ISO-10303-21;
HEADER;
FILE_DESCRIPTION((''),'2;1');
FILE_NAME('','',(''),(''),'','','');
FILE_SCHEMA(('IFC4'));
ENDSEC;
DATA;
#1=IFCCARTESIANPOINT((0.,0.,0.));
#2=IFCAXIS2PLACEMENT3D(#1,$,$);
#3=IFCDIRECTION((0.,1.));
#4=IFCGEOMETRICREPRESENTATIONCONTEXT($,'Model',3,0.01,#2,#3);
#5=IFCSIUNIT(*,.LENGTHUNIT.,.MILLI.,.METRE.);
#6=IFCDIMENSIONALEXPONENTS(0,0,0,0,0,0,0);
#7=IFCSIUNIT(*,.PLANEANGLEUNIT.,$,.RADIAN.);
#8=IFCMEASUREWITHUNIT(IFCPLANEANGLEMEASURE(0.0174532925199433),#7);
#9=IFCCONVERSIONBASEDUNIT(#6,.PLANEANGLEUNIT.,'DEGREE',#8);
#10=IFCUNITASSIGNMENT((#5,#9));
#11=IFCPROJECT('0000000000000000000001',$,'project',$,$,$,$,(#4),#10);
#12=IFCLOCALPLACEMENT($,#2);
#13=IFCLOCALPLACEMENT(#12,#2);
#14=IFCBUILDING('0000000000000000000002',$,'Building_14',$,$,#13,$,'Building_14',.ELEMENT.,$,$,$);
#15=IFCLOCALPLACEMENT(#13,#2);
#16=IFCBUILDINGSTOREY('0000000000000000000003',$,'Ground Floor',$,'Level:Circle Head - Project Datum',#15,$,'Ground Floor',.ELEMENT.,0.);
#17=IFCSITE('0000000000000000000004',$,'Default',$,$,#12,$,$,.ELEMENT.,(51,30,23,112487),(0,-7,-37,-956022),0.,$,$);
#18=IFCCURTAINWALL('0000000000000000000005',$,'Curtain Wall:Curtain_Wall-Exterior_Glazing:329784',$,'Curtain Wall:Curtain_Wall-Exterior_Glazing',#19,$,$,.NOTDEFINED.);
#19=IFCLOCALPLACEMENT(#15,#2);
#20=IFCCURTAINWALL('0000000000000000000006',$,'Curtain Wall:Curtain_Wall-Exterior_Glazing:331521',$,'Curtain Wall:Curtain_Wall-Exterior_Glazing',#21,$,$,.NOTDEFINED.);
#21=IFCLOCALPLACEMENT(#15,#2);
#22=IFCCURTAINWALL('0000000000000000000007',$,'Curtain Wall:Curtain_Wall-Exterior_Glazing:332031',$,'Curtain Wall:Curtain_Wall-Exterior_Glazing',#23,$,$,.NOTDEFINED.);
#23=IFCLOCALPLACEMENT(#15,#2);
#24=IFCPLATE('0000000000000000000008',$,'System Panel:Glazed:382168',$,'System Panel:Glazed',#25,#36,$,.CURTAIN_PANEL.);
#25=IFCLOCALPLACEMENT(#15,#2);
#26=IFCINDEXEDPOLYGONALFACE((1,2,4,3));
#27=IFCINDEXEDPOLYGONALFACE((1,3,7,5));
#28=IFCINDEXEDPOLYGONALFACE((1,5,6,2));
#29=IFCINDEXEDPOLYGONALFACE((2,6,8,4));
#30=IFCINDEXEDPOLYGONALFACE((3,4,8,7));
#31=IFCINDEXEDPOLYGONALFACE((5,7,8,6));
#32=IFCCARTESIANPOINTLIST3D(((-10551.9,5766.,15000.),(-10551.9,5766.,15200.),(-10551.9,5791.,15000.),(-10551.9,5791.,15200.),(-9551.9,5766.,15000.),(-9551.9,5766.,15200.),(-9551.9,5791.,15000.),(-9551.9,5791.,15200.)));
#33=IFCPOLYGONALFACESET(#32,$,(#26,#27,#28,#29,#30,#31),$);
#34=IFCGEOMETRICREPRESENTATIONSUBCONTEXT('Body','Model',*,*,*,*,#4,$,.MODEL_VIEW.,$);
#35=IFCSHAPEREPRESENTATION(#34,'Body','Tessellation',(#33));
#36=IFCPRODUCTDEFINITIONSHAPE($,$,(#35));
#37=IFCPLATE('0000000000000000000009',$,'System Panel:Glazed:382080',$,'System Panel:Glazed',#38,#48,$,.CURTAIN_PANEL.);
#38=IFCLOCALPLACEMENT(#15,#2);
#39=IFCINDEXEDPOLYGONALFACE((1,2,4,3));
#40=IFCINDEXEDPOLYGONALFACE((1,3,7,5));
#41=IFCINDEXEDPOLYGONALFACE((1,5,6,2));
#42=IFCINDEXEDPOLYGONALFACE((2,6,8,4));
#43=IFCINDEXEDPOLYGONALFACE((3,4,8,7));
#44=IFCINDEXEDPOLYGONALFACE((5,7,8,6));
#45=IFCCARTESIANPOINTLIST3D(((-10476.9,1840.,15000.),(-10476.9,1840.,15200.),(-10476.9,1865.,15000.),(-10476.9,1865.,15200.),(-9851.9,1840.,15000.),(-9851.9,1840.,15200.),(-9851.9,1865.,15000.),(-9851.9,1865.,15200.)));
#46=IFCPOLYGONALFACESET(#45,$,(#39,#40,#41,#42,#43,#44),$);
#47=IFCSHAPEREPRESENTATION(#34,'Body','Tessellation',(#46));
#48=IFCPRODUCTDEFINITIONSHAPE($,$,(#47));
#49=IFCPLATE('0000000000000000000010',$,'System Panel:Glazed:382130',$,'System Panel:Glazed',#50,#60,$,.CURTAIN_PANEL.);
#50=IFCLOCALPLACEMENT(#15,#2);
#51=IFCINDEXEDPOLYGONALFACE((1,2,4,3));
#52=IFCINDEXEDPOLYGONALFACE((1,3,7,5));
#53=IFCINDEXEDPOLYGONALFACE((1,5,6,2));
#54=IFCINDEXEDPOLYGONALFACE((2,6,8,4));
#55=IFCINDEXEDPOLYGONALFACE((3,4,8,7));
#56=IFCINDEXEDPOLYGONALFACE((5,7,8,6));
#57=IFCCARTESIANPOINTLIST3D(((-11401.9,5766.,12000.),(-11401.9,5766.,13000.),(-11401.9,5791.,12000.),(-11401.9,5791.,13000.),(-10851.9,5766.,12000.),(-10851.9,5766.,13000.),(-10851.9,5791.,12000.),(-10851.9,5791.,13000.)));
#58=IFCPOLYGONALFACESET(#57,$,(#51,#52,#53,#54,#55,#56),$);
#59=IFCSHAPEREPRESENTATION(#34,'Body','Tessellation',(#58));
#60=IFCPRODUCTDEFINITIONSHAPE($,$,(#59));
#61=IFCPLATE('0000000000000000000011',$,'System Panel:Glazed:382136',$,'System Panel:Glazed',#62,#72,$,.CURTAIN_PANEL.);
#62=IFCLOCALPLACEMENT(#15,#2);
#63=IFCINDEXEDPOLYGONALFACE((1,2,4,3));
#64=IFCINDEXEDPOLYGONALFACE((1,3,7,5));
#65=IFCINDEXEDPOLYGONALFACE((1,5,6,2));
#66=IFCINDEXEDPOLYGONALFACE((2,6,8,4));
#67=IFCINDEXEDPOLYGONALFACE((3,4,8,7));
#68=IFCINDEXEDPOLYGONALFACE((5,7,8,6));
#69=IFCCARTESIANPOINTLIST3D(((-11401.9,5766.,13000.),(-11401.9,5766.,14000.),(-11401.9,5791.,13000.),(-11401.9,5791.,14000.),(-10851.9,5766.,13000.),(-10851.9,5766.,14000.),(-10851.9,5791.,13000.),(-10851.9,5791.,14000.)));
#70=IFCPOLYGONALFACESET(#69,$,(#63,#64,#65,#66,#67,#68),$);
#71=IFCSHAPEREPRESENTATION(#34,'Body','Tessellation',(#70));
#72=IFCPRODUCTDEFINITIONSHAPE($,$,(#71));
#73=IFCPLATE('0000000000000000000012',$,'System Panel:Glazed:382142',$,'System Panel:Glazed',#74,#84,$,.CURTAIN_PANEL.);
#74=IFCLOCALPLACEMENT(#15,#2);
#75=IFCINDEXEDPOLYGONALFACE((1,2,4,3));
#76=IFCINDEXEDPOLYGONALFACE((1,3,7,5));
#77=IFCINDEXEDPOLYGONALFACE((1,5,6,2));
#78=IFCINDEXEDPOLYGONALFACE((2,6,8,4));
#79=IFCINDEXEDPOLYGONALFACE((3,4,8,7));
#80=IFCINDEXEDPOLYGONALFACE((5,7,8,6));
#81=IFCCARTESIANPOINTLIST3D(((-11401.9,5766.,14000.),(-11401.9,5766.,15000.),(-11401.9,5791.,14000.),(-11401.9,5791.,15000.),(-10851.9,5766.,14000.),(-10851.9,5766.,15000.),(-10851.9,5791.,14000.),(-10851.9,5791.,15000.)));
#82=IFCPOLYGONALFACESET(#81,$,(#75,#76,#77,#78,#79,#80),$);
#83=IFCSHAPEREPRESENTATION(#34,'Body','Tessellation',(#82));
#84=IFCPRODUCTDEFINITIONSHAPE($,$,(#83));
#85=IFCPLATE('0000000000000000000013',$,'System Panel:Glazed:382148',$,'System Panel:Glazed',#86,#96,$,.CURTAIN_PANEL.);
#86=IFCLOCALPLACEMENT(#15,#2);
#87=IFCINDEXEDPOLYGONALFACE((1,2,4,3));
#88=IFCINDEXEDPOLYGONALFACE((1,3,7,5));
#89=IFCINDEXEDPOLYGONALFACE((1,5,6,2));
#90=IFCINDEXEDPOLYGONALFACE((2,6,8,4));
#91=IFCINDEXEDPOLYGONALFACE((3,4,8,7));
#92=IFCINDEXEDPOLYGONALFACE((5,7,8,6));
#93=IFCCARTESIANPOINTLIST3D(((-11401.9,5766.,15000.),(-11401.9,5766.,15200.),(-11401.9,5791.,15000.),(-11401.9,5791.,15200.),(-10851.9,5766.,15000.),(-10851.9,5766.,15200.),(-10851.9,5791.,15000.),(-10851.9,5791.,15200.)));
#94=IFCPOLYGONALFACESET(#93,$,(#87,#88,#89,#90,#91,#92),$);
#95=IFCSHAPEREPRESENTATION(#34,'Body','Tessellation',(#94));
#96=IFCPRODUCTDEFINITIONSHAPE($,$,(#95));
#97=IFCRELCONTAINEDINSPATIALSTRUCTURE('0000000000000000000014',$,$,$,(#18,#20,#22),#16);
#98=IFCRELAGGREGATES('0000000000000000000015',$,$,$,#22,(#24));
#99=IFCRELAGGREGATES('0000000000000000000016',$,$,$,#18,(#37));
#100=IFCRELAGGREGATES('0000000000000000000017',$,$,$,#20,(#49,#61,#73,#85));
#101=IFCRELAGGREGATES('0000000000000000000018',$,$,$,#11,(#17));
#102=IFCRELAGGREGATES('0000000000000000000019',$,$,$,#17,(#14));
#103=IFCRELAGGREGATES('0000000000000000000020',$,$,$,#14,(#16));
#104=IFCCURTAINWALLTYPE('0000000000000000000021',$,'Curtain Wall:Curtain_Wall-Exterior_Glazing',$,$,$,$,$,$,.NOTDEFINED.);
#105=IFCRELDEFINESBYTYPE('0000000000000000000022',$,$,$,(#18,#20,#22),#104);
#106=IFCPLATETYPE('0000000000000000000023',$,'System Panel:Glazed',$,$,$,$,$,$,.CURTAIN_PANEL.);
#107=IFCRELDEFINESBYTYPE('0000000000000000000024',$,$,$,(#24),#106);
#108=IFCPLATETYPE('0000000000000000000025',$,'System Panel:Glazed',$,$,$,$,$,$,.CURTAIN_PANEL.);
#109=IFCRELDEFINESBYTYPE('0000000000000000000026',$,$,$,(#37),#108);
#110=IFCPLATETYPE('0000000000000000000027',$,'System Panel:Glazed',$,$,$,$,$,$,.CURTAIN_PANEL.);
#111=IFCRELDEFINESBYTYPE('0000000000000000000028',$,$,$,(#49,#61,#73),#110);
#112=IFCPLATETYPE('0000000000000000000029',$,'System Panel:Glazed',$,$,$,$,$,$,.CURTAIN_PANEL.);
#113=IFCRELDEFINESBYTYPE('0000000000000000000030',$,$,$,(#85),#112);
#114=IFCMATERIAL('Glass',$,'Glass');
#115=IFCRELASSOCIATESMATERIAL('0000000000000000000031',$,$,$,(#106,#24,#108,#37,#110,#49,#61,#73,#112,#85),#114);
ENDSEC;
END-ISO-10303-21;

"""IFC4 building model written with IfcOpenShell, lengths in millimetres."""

from ifc_helpers import new_model, entity, si_unit, converted_unit, direction, frame, origin, place, context, subcontext, project, spatial, indexed_curve, outline, extrude, source, transform, mapped, material, type_object, type_shapes, element, aggregate, save


model = new_model("IFC4")

# Units and contexts
model_context = context("Model", 3, precision=0.01, world=origin(), true_north=direction((0.0, 1.0)))
body_context = subcontext(model_context, "Body", "Model", "MODEL_VIEW")
ifc_project = project(units=[si_unit("LENGTHUNIT", "METRE", prefix="MILLI"), converted_unit("PLANEANGLEUNIT", "DEGREE", entity("IfcPlaneAngleMeasure", 0.0174532925199433), si_unit("PLANEANGLEUNIT", "RADIAN"), dimensions=[0, 0, 0, 0, 0, 0, 0])], contexts=[model_context])

# Site, building, storey
site_placement = place(None, origin())
site = spatial("IfcSite", under=ifc_project, at=site_placement, Name="Default", CompositionType="ELEMENT", RefLatitude=(51, 30, 23, 112487), RefLongitude=(0, -7, -37, -956022), RefElevation=0.0)
building_placement = place(site_placement, origin())
building = spatial("IfcBuilding", under=site, at=building_placement, Name="Building_14", LongName="Building_14", CompositionType="ELEMENT")
storey_placement = place(building_placement, origin())
storey = spatial("IfcBuildingStorey", under=building, at=storey_placement, Name="Ground Floor", ObjectType="Level:Circle Head - Project Datum", LongName="Ground Floor", CompositionType="ELEMENT", Elevation=0.0)

# Curtain walls
curtain_wall_type = type_object("IfcCurtainWallType", Name="Curtain Wall:Curtain_Wall-Exterior_Glazing", PredefinedType="NOTDEFINED")
curtain_wall_1_placement = place(storey_placement, origin())
curtain_wall_1 = element("IfcCurtainWall", 1, at=curtain_wall_1_placement, inside=storey, type_object=curtain_wall_type, Name="Curtain Wall:Curtain_Wall-Exterior_Glazing:329784", ObjectType="Curtain Wall:Curtain_Wall-Exterior_Glazing", PredefinedType="NOTDEFINED")
ifc_material = material(Name="Glass", Category="Glass")
curtain_wall_2_placement = place(storey_placement, origin())
curtain_wall_2 = element("IfcCurtainWall", 2, at=curtain_wall_2_placement, inside=storey, type_object=curtain_wall_type, Name="Curtain Wall:Curtain_Wall-Exterior_Glazing:331521", ObjectType="Curtain Wall:Curtain_Wall-Exterior_Glazing", PredefinedType="NOTDEFINED")
curtain_wall_3_placement = place(storey_placement, origin())
curtain_wall_3 = element("IfcCurtainWall", 3, at=curtain_wall_3_placement, inside=storey, type_object=curtain_wall_type, Name="Curtain Wall:Curtain_Wall-Exterior_Glazing:332031", ObjectType="Curtain Wall:Curtain_Wall-Exterior_Glazing", PredefinedType="NOTDEFINED")

# Plates
plate_type_1 = type_object("IfcPlateType", Name="System Panel:Glazed", PredefinedType="CURTAIN_PANEL", material=ifc_material)
shared_shape_1 = source(origin(), body_context, "Body", "SweptSolid", [
    extrude(outline(indexed_curve([(-12.5, -500.0), (12.5, -500.0), (12.5, 500.0), (-12.5, 500.0), (-12.5, -500.0)], self_intersect=False)), frame((0.0, -37.0, 0.0), z_axis=(0.0, 0.0, 1.0), x_axis=(0.0, 1.0, 0.0)), (0.0, 0.0, 1.0), 200.0),
])
type_shapes(plate_type_1, [shared_shape_1])
plate_1_placement = place(curtain_wall_3_placement, frame((-10051.9, 5815.5, 15000.0)))
plate_1 = element("IfcPlate", 4, at=plate_1_placement, type_object=plate_type_1, material=ifc_material, Name="System Panel:Glazed:382168", ObjectType="System Panel:Glazed", PredefinedType="CURTAIN_PANEL", context=body_context, shape_type="MappedRepresentation", body=[
    mapped(shared_shape_1, transform((0.0, 0.0, 0.0), scale=1.0)),
])
aggregate(curtain_wall_3, [plate_1])
plate_type_2 = type_object("IfcPlateType", Name="System Panel:Glazed", PredefinedType="CURTAIN_PANEL", material=ifc_material)
shared_shape_2 = source(origin(), body_context, "Body", "SweptSolid", [
    extrude(outline(indexed_curve([(-12.5, -312.5), (12.5, -312.5), (12.5, 312.5), (-12.5, 312.5), (-12.5, -312.5)], self_intersect=False)), frame((0.0, -37.0, 0.0), z_axis=(0.0, 0.0, 1.0), x_axis=(0.0, 1.0, 0.0)), (0.0, 0.0, 1.0), 200.0),
])
type_shapes(plate_type_2, [shared_shape_2])
plate_2_placement = place(curtain_wall_1_placement, frame((-10164.4, 1815.5, 15000.0), z_axis=(0.0, 0.0, 1.0), x_axis=(-1.0, 0.0, 0.0)))
plate_2 = element("IfcPlate", 5, at=plate_2_placement, type_object=plate_type_2, material=ifc_material, Name="System Panel:Glazed:382080", ObjectType="System Panel:Glazed", PredefinedType="CURTAIN_PANEL", context=body_context, shape_type="MappedRepresentation", body=[
    mapped(shared_shape_2, transform((0.0, 0.0, 0.0), scale=1.0)),
])
aggregate(curtain_wall_1, [plate_2])
plate_type_3 = type_object("IfcPlateType", Name="System Panel:Glazed", PredefinedType="CURTAIN_PANEL", material=ifc_material)
shared_shape_3 = source(origin(), body_context, "Body", "SweptSolid", [
    extrude(outline(indexed_curve([(-12.5, -275.0), (12.5, -275.0), (12.5, 275.0), (-12.5, 275.0), (-12.5, -275.0)], self_intersect=False)), frame((0.0, -37.0, 0.0), z_axis=(0.0, 0.0, 1.0), x_axis=(0.0, 1.0, 0.0)), (0.0, 0.0, 1.0), 1000.0),
])
type_shapes(plate_type_3, [shared_shape_3])
plate_3_placement = place(curtain_wall_2_placement, frame((-11126.9, 5815.5, 12000.0)))
plate_3 = element("IfcPlate", 6, at=plate_3_placement, type_object=plate_type_3, material=ifc_material, Name="System Panel:Glazed:382130", ObjectType="System Panel:Glazed", PredefinedType="CURTAIN_PANEL", context=body_context, shape_type="MappedRepresentation", body=[
    mapped(shared_shape_3, transform((0.0, 0.0, 0.0), scale=1.0)),
])
plate_4_placement = place(curtain_wall_2_placement, frame((-11126.9, 5815.5, 13000.0)))
plate_4 = element("IfcPlate", 7, at=plate_4_placement, type_object=plate_type_3, material=ifc_material, Name="System Panel:Glazed:382136", ObjectType="System Panel:Glazed", PredefinedType="CURTAIN_PANEL", context=body_context, shape_type="MappedRepresentation", body=[
    mapped(shared_shape_3, transform((0.0, 0.0, 0.0), scale=1.0)),
])
plate_5_placement = place(curtain_wall_2_placement, frame((-11126.9, 5815.5, 14000.0)))
plate_5 = element("IfcPlate", 8, at=plate_5_placement, type_object=plate_type_3, material=ifc_material, Name="System Panel:Glazed:382142", ObjectType="System Panel:Glazed", PredefinedType="CURTAIN_PANEL", context=body_context, shape_type="MappedRepresentation", body=[
    mapped(shared_shape_3, transform((0.0, 0.0, 0.0), scale=1.0)),
])
plate_type_4 = type_object("IfcPlateType", Name="System Panel:Glazed", PredefinedType="CURTAIN_PANEL", material=ifc_material)
shared_shape_4 = source(origin(), body_context, "Body", "SweptSolid", [
    extrude(outline(indexed_curve([(-12.5, -275.0), (12.5, -275.0), (12.5, 275.0), (-12.5, 275.0), (-12.5, -275.0)], self_intersect=False)), frame((0.0, -37.0, 0.0), z_axis=(0.0, 0.0, 1.0), x_axis=(0.0, 1.0, 0.0)), (0.0, 0.0, 1.0), 200.0),
])
type_shapes(plate_type_4, [shared_shape_4])
plate_6_placement = place(curtain_wall_2_placement, frame((-11126.9, 5815.5, 15000.0)))
plate_6 = element("IfcPlate", 9, at=plate_6_placement, type_object=plate_type_4, material=ifc_material, Name="System Panel:Glazed:382148", ObjectType="System Panel:Glazed", PredefinedType="CURTAIN_PANEL", context=body_context, shape_type="MappedRepresentation", body=[
    mapped(shared_shape_4, transform((0.0, 0.0, 0.0), scale=1.0)),
])
aggregate(curtain_wall_2, [plate_3, plate_4, plate_5, plate_6])

save(model, "model.ifc")
